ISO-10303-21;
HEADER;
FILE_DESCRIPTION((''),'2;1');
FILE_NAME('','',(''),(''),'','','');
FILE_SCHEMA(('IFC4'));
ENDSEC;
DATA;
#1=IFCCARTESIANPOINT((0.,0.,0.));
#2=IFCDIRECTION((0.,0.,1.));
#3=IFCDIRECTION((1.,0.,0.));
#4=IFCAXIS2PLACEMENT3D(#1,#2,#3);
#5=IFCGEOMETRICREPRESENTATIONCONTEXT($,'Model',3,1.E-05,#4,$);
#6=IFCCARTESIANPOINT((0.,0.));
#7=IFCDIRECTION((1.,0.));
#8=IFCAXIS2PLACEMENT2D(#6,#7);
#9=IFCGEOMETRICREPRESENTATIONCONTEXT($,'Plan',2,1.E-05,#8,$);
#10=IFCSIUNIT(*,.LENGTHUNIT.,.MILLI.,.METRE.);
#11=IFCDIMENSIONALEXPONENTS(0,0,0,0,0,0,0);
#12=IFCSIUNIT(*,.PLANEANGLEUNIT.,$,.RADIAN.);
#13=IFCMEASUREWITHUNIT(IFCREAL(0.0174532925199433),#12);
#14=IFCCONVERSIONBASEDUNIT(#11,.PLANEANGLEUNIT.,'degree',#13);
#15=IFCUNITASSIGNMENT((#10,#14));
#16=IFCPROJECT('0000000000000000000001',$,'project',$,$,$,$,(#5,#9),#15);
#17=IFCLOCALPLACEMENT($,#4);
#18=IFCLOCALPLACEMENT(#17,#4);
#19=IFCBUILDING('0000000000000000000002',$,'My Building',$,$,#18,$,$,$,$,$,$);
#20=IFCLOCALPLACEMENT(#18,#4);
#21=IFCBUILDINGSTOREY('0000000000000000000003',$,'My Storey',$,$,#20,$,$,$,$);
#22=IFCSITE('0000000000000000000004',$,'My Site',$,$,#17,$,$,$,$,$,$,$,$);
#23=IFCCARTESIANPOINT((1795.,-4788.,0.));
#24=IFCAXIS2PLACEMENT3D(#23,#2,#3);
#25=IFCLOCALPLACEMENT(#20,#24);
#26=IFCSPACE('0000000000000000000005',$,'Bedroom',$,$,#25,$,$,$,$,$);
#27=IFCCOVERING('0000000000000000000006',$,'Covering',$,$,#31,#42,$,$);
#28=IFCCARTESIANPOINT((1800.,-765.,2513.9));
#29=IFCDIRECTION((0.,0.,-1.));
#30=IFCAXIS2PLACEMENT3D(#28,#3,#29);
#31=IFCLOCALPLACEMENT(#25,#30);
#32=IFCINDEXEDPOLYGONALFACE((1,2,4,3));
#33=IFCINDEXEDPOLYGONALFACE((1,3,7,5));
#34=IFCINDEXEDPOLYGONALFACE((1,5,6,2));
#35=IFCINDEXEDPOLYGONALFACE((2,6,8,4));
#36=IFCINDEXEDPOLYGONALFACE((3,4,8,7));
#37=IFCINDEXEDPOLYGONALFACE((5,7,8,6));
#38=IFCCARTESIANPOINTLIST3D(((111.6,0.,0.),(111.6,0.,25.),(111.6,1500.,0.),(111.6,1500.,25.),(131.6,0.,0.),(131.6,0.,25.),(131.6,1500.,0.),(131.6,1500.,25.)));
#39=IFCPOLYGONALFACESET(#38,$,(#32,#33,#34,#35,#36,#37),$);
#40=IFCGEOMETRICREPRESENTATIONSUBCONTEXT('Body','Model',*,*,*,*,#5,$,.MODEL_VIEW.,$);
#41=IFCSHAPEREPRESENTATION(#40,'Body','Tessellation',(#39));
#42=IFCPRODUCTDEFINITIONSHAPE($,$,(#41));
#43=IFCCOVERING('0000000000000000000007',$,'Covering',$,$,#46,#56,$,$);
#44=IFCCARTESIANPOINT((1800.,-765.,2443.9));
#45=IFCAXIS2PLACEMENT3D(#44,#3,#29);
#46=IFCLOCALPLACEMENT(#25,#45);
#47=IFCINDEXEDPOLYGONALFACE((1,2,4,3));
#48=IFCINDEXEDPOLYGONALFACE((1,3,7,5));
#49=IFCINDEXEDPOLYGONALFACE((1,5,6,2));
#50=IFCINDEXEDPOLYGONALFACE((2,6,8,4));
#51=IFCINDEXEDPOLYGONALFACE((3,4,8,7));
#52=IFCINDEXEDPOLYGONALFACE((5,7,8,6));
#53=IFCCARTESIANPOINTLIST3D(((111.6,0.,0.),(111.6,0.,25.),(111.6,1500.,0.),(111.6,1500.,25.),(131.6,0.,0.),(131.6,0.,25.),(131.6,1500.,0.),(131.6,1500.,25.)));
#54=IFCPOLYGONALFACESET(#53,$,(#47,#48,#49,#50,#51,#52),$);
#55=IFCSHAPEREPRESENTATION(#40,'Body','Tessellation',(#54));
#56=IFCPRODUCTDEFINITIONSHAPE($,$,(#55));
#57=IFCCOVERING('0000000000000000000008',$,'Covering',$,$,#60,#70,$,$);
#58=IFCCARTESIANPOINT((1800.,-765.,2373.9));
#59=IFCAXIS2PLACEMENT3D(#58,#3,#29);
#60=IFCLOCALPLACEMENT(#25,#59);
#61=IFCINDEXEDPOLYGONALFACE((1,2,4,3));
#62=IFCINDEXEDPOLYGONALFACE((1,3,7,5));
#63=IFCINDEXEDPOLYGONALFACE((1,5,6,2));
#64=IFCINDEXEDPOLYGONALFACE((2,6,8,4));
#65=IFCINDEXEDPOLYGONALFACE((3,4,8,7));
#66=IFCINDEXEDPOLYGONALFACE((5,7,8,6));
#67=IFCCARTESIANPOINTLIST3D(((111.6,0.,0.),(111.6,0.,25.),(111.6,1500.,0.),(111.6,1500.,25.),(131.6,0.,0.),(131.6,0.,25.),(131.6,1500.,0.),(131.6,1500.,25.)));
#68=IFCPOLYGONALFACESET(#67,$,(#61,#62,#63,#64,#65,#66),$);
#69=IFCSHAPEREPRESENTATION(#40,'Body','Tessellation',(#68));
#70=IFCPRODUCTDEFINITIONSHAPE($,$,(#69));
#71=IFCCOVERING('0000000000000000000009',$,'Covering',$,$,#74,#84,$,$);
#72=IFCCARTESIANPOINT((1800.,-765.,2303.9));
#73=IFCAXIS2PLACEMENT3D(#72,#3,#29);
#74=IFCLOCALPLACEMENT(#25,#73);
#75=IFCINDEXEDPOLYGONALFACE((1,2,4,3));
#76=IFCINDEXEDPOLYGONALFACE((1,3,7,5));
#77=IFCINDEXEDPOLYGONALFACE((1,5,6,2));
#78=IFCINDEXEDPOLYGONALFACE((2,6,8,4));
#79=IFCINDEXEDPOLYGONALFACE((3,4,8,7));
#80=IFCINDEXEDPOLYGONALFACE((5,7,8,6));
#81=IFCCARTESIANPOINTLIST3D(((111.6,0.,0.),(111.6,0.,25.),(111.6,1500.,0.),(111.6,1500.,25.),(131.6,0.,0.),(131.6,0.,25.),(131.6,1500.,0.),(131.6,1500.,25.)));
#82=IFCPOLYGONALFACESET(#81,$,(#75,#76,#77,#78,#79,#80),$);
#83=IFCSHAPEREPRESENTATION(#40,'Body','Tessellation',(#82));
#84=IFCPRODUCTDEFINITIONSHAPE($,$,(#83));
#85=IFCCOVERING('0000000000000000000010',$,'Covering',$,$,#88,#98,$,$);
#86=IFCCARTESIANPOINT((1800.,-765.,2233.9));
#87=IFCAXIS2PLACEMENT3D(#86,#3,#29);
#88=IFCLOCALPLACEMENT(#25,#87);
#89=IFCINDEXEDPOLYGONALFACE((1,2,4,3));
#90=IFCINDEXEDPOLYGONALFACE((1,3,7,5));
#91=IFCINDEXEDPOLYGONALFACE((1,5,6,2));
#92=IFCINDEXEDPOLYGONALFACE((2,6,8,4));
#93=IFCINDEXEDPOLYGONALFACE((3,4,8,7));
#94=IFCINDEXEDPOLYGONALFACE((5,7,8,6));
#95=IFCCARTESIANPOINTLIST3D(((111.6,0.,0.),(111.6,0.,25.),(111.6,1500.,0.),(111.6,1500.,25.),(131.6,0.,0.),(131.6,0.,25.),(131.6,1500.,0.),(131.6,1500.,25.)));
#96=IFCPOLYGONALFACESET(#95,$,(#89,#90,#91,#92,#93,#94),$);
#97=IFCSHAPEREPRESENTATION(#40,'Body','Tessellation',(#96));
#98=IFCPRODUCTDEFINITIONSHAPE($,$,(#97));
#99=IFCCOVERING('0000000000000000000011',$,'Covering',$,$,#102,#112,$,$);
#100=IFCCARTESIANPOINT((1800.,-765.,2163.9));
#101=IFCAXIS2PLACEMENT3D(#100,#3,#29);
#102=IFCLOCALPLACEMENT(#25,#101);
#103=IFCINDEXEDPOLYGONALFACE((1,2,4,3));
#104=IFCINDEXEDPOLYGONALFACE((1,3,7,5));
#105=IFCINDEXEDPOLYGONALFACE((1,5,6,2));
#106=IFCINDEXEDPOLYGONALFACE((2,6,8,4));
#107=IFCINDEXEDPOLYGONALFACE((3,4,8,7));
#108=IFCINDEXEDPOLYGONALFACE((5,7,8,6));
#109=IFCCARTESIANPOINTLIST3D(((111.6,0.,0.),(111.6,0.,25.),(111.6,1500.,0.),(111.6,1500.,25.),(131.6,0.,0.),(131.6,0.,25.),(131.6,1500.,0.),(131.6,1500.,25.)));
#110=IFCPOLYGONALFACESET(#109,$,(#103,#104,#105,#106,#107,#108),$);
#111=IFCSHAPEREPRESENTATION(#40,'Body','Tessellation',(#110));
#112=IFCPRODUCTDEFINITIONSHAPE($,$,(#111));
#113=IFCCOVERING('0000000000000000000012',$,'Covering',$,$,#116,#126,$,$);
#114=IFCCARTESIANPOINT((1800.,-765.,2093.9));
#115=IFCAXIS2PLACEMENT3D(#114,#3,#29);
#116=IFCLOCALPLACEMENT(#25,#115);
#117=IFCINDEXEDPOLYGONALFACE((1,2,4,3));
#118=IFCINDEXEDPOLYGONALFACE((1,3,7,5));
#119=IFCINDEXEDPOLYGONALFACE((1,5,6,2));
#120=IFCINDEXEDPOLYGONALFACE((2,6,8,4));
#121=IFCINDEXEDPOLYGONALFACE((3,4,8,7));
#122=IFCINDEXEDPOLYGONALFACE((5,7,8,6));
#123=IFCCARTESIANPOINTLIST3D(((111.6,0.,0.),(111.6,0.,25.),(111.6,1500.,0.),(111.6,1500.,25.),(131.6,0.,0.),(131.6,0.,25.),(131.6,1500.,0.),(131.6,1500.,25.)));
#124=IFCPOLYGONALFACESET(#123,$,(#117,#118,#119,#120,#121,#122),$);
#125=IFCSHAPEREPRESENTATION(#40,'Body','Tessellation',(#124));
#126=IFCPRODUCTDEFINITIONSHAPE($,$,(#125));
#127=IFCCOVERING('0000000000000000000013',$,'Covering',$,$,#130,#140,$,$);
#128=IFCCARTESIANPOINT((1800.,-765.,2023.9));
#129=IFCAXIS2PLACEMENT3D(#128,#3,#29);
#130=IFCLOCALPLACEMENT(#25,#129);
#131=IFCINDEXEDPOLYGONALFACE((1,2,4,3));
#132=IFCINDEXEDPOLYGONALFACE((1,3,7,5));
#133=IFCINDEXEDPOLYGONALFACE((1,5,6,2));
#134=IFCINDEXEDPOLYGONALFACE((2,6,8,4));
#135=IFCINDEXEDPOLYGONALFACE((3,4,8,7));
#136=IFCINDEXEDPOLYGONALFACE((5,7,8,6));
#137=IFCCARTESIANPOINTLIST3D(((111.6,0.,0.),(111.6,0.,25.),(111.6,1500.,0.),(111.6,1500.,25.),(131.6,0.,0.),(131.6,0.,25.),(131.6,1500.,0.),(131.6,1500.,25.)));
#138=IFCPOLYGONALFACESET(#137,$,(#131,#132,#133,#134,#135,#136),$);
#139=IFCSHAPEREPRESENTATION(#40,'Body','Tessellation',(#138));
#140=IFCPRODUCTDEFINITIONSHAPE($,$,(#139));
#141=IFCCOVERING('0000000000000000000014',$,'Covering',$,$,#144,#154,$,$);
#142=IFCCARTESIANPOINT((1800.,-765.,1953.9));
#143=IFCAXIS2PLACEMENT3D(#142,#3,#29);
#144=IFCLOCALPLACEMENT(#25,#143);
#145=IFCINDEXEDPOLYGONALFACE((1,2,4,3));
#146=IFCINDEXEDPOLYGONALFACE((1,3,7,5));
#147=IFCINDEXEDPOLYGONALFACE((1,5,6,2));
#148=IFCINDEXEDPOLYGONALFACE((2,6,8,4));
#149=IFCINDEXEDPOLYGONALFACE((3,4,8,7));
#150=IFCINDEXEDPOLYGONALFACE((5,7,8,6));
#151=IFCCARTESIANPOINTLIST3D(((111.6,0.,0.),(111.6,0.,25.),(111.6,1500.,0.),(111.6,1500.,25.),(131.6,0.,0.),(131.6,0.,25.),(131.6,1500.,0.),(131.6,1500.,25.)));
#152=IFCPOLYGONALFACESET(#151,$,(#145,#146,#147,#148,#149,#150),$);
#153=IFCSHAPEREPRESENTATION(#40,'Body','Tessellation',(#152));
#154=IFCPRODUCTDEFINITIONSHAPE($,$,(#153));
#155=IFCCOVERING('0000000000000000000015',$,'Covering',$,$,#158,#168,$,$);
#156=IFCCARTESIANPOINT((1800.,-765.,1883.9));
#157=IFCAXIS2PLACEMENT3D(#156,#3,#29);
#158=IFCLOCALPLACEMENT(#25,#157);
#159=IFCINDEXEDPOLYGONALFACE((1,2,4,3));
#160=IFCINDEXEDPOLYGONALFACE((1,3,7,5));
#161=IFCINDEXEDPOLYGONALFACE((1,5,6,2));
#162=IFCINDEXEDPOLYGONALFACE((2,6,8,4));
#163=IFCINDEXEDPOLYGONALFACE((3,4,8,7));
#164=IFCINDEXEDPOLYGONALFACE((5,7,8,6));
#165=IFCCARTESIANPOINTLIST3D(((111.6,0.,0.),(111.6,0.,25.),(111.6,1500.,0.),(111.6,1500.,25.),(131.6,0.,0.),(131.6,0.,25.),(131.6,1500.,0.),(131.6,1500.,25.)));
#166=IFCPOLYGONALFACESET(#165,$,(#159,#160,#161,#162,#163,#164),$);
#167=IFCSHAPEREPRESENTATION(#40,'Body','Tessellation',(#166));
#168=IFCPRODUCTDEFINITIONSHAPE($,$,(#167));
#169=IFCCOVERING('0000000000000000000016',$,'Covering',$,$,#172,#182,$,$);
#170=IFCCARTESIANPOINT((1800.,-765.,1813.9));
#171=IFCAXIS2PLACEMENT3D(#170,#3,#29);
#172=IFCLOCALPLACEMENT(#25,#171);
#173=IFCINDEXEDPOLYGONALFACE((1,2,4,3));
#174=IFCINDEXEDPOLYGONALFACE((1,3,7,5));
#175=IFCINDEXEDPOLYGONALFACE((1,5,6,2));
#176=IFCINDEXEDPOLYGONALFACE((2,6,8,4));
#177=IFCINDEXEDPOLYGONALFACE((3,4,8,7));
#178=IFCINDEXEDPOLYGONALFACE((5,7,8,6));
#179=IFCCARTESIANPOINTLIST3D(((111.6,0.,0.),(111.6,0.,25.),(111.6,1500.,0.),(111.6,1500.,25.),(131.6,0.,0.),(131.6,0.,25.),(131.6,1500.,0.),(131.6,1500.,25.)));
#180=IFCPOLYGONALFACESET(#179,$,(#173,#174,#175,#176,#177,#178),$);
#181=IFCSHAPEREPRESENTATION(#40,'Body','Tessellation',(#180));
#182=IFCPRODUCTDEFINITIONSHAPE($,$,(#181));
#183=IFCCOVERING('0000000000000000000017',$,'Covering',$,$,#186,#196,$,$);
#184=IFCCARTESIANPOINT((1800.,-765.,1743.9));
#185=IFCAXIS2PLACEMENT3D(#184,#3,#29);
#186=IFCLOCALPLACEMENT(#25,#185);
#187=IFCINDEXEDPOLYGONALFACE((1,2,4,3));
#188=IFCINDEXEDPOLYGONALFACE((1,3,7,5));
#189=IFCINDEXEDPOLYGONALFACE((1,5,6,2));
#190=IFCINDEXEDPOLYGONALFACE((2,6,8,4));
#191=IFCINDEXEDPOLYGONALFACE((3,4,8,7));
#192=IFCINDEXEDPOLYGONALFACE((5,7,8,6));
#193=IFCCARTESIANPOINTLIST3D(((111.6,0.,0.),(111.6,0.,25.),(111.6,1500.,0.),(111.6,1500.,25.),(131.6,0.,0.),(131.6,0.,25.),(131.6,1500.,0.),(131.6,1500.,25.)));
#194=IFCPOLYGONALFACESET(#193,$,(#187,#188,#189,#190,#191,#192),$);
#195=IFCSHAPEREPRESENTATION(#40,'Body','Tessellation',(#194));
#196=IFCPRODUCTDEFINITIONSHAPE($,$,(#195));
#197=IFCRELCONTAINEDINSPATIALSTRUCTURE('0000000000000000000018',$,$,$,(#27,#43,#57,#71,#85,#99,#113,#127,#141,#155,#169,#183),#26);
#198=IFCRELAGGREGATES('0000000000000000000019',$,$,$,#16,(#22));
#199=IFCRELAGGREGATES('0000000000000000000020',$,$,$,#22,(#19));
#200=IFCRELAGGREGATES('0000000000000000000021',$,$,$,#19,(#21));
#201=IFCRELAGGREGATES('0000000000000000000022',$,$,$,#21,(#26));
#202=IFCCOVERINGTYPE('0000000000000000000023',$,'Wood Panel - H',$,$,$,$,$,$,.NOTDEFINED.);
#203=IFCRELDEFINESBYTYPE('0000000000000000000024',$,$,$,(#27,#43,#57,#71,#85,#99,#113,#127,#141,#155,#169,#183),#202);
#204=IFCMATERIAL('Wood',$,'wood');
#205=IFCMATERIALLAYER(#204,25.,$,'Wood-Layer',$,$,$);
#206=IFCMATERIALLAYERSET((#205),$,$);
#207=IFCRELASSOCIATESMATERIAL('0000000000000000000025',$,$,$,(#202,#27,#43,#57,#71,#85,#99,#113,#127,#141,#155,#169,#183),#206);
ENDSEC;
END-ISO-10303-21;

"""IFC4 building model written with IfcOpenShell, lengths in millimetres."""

from ifc_helpers import new_model, entity, si_unit, converted_unit, frame, origin_with_axes, origin_2d_with_axis, place, context, subcontext, project, spatial, line, indexed_curve, outline, extrude, material, layer, layer_set, layer_usage, type_object, element, save


model = new_model("IFC4")

# Units and contexts
model_context = context("Model", 3, precision=1e-05, world=origin_with_axes())
plan_context = context("Plan", 2, precision=1e-05, world=origin_2d_with_axis())
body_context_1 = subcontext(model_context, "Body", "Model", "MODEL_VIEW")
ifc_project = project(units=[si_unit("LENGTHUNIT", "METRE", prefix="MILLI"), converted_unit("PLANEANGLEUNIT", "degree", entity("IfcReal", 0.0174532925199433), si_unit("PLANEANGLEUNIT", "RADIAN"), dimensions=[0, 0, 0, 0, 0, 0, 0])], contexts=[model_context, plan_context])

# Site, building, storey
site_placement = place(None, origin_with_axes())
site = spatial("IfcSite", under=ifc_project, at=site_placement, Name="My Site")
building_placement = place(site_placement, origin_with_axes())
building = spatial("IfcBuilding", under=site, at=building_placement, Name="My Building")
storey_placement = place(building_placement, origin_with_axes())
storey = spatial("IfcBuildingStorey", under=building, at=storey_placement, Name="My Storey")

# Shared definitions
space_placement = place(storey_placement, frame((1795.0, -4788.0, 0.0), z_axis=(0.0, 0.0, 1.0), x_axis=(1.0, 0.0, 0.0)))
space = spatial("IfcSpace", under=storey, at=space_placement, Name="Bedroom")

# Coverings
ifc_material_1 = material(Name="Wood", Category="wood")
ifc_layer_1 = layer(ifc_material_1, 25.0, Name="Wood-Layer")
ifc_layer_set_1 = layer_set([ifc_layer_1])
ifc_layer_usage_1 = layer_usage(ifc_layer_set_1, "AXIS3", "POSITIVE", 0.0)
covering_type_1 = type_object("IfcCoveringType", Name="Wood Panel - H", PredefinedType="NOTDEFINED", material=ifc_layer_set_1)
covering_1_placement = place(space_placement, frame((1800.0, -765.0, 2513.9), z_axis=(1.0, 0.0, 0.0), x_axis=(0.0, 0.0, -1.0)))
element("IfcCovering", 1, at=covering_1_placement, inside=space, type_object=covering_type_1, material=ifc_layer_usage_1, Name="Covering", context=body_context_1, shape_type="SweptSolid", body=[
    extrude(outline(indexed_curve([(131.6, 1500.0), (111.6, 1500.0), (111.6, 0.0), (131.6, 0.0)], segments=[line(3, 2), line(2, 1), line(1, 4), line(4, 3)], self_intersect=False)), None, (0.0, 0.0, 1.0), 25.0),
])
ifc_layer_usage_2 = layer_usage(ifc_layer_set_1, "AXIS3", "POSITIVE", 0.0)
covering_2_placement = place(space_placement, frame((1800.0, -765.0, 2443.9), z_axis=(1.0, 0.0, 0.0), x_axis=(0.0, 0.0, -1.0)))
element("IfcCovering", 2, at=covering_2_placement, inside=space, type_object=covering_type_1, material=ifc_layer_usage_2, Name="Covering", context=body_context_1, shape_type="SweptSolid", body=[
    extrude(outline(indexed_curve([(131.6, 1500.0), (111.6, 1500.0), (111.6, 0.0), (131.6, 0.0)], segments=[line(3, 2), line(2, 1), line(1, 4), line(4, 3)], self_intersect=False)), None, (0.0, 0.0, 1.0), 25.0),
])
ifc_layer_usage_3 = layer_usage(ifc_layer_set_1, "AXIS3", "POSITIVE", 0.0)
covering_3_placement = place(space_placement, frame((1800.0, -765.0, 2373.9), z_axis=(1.0, 0.0, 0.0), x_axis=(0.0, 0.0, -1.0)))
element("IfcCovering", 3, at=covering_3_placement, inside=space, type_object=covering_type_1, material=ifc_layer_usage_3, Name="Covering", context=body_context_1, shape_type="SweptSolid", body=[
    extrude(outline(indexed_curve([(131.6, 1500.0), (111.6, 1500.0), (111.6, 0.0), (131.6, 0.0)], segments=[line(3, 2), line(2, 1), line(1, 4), line(4, 3)], self_intersect=False)), None, (0.0, 0.0, 1.0), 25.0),
])
ifc_layer_usage_4 = layer_usage(ifc_layer_set_1, "AXIS3", "POSITIVE", 0.0)
covering_4_placement = place(space_placement, frame((1800.0, -765.0, 2303.9), z_axis=(1.0, 0.0, 0.0), x_axis=(0.0, 0.0, -1.0)))
element("IfcCovering", 4, at=covering_4_placement, inside=space, type_object=covering_type_1, material=ifc_layer_usage_4, Name="Covering", context=body_context_1, shape_type="SweptSolid", body=[
    extrude(outline(indexed_curve([(131.6, 1500.0), (111.6, 1500.0), (111.6, 0.0), (131.6, 0.0)], segments=[line(3, 2), line(2, 1), line(1, 4), line(4, 3)], self_intersect=False)), None, (0.0, 0.0, 1.0), 25.0),
])
ifc_layer_usage_5 = layer_usage(ifc_layer_set_1, "AXIS3", "POSITIVE", 0.0)
covering_5_placement = place(space_placement, frame((1800.0, -765.0, 2233.9), z_axis=(1.0, 0.0, 0.0), x_axis=(0.0, 0.0, -1.0)))
element("IfcCovering", 5, at=covering_5_placement, inside=space, type_object=covering_type_1, material=ifc_layer_usage_5, Name="Covering", context=body_context_1, shape_type="SweptSolid", body=[
    extrude(outline(indexed_curve([(131.6, 1500.0), (111.6, 1500.0), (111.6, 0.0), (131.6, 0.0)], segments=[line(3, 2), line(2, 1), line(1, 4), line(4, 3)], self_intersect=False)), None, (0.0, 0.0, 1.0), 25.0),
])
ifc_layer_usage_6 = layer_usage(ifc_layer_set_1, "AXIS3", "POSITIVE", 0.0)
covering_6_placement = place(space_placement, frame((1800.0, -765.0, 2163.9), z_axis=(1.0, 0.0, 0.0), x_axis=(0.0, 0.0, -1.0)))
element("IfcCovering", 6, at=covering_6_placement, inside=space, type_object=covering_type_1, material=ifc_layer_usage_6, Name="Covering", context=body_context_1, shape_type="SweptSolid", body=[
    extrude(outline(indexed_curve([(131.6, 1500.0), (111.6, 1500.0), (111.6, 0.0), (131.6, 0.0)], segments=[line(3, 2), line(2, 1), line(1, 4), line(4, 3)], self_intersect=False)), None, (0.0, 0.0, 1.0), 25.0),
])
ifc_layer_usage_7 = layer_usage(ifc_layer_set_1, "AXIS3", "POSITIVE", 0.0)
covering_7_placement = place(space_placement, frame((1800.0, -765.0, 2093.9), z_axis=(1.0, 0.0, 0.0), x_axis=(0.0, 0.0, -1.0)))
element("IfcCovering", 7, at=covering_7_placement, inside=space, type_object=covering_type_1, material=ifc_layer_usage_7, Name="Covering", context=body_context_1, shape_type="SweptSolid", body=[
    extrude(outline(indexed_curve([(131.6, 1500.0), (111.6, 1500.0), (111.6, 0.0), (131.6, 0.0)], segments=[line(3, 2), line(2, 1), line(1, 4), line(4, 3)], self_intersect=False)), None, (0.0, 0.0, 1.0), 25.0),
])
ifc_layer_usage_8 = layer_usage(ifc_layer_set_1, "AXIS3", "POSITIVE", 0.0)
covering_8_placement = place(space_placement, frame((1800.0, -765.0, 2023.9), z_axis=(1.0, 0.0, 0.0), x_axis=(0.0, 0.0, -1.0)))
element("IfcCovering", 8, at=covering_8_placement, inside=space, type_object=covering_type_1, material=ifc_layer_usage_8, Name="Covering", context=body_context_1, shape_type="SweptSolid", body=[
    extrude(outline(indexed_curve([(131.6, 1500.0), (111.6, 1500.0), (111.6, 0.0), (131.6, 0.0)], segments=[line(3, 2), line(2, 1), line(1, 4), line(4, 3)], self_intersect=False)), None, (0.0, 0.0, 1.0), 25.0),
])
ifc_layer_usage_9 = layer_usage(ifc_layer_set_1, "AXIS3", "POSITIVE", 0.0)
covering_9_placement = place(space_placement, frame((1800.0, -765.0, 1953.9), z_axis=(1.0, 0.0, 0.0), x_axis=(0.0, 0.0, -1.0)))
element("IfcCovering", 9, at=covering_9_placement, inside=space, type_object=covering_type_1, material=ifc_layer_usage_9, Name="Covering", context=body_context_1, shape_type="SweptSolid", body=[
    extrude(outline(indexed_curve([(131.6, 1500.0), (111.6, 1500.0), (111.6, 0.0), (131.6, 0.0)], segments=[line(3, 2), line(2, 1), line(1, 4), line(4, 3)], self_intersect=False)), None, (0.0, 0.0, 1.0), 25.0),
])
ifc_layer_usage_10 = layer_usage(ifc_layer_set_1, "AXIS3", "POSITIVE", 0.0)
covering_10_placement = place(space_placement, frame((1800.0, -765.0, 1883.9), z_axis=(1.0, 0.0, 0.0), x_axis=(0.0, 0.0, -1.0)))
element("IfcCovering", 10, at=covering_10_placement, inside=space, type_object=covering_type_1, material=ifc_layer_usage_10, Name="Covering", context=body_context_1, shape_type="SweptSolid", body=[
    extrude(outline(indexed_curve([(131.6, 1500.0), (111.6, 1500.0), (111.6, 0.0), (131.6, 0.0)], segments=[line(3, 2), line(2, 1), line(1, 4), line(4, 3)], self_intersect=False)), None, (0.0, 0.0, 1.0), 25.0),
])
ifc_layer_usage_11 = layer_usage(ifc_layer_set_1, "AXIS3", "POSITIVE", 0.0)
covering_11_placement = place(space_placement, frame((1800.0, -765.0, 1813.9), z_axis=(1.0, 0.0, 0.0), x_axis=(0.0, 0.0, -1.0)))
element("IfcCovering", 11, at=covering_11_placement, inside=space, type_object=covering_type_1, material=ifc_layer_usage_11, Name="Covering", context=body_context_1, shape_type="SweptSolid", body=[
    extrude(outline(indexed_curve([(131.6, 1500.0), (111.6, 1500.0), (111.6, 0.0), (131.6, 0.0)], segments=[line(3, 2), line(2, 1), line(1, 4), line(4, 3)], self_intersect=False)), None, (0.0, 0.0, 1.0), 25.0),
])
ifc_layer_usage_12 = layer_usage(ifc_layer_set_1, "AXIS3", "POSITIVE", 0.0)
covering_12_placement = place(space_placement, frame((1800.0, -765.0, 1743.9), z_axis=(1.0, 0.0, 0.0), x_axis=(0.0, 0.0, -1.0)))
element("IfcCovering", 12, at=covering_12_placement, inside=space, type_object=covering_type_1, material=ifc_layer_usage_12, Name="Covering", context=body_context_1, shape_type="SweptSolid", body=[
    extrude(outline(indexed_curve([(131.6, 1500.0), (111.6, 1500.0), (111.6, 0.0), (131.6, 0.0)], segments=[line(3, 2), line(2, 1), line(1, 4), line(4, 3)], self_intersect=False)), None, (0.0, 0.0, 1.0), 25.0),
])

save(model, "model.ifc")
